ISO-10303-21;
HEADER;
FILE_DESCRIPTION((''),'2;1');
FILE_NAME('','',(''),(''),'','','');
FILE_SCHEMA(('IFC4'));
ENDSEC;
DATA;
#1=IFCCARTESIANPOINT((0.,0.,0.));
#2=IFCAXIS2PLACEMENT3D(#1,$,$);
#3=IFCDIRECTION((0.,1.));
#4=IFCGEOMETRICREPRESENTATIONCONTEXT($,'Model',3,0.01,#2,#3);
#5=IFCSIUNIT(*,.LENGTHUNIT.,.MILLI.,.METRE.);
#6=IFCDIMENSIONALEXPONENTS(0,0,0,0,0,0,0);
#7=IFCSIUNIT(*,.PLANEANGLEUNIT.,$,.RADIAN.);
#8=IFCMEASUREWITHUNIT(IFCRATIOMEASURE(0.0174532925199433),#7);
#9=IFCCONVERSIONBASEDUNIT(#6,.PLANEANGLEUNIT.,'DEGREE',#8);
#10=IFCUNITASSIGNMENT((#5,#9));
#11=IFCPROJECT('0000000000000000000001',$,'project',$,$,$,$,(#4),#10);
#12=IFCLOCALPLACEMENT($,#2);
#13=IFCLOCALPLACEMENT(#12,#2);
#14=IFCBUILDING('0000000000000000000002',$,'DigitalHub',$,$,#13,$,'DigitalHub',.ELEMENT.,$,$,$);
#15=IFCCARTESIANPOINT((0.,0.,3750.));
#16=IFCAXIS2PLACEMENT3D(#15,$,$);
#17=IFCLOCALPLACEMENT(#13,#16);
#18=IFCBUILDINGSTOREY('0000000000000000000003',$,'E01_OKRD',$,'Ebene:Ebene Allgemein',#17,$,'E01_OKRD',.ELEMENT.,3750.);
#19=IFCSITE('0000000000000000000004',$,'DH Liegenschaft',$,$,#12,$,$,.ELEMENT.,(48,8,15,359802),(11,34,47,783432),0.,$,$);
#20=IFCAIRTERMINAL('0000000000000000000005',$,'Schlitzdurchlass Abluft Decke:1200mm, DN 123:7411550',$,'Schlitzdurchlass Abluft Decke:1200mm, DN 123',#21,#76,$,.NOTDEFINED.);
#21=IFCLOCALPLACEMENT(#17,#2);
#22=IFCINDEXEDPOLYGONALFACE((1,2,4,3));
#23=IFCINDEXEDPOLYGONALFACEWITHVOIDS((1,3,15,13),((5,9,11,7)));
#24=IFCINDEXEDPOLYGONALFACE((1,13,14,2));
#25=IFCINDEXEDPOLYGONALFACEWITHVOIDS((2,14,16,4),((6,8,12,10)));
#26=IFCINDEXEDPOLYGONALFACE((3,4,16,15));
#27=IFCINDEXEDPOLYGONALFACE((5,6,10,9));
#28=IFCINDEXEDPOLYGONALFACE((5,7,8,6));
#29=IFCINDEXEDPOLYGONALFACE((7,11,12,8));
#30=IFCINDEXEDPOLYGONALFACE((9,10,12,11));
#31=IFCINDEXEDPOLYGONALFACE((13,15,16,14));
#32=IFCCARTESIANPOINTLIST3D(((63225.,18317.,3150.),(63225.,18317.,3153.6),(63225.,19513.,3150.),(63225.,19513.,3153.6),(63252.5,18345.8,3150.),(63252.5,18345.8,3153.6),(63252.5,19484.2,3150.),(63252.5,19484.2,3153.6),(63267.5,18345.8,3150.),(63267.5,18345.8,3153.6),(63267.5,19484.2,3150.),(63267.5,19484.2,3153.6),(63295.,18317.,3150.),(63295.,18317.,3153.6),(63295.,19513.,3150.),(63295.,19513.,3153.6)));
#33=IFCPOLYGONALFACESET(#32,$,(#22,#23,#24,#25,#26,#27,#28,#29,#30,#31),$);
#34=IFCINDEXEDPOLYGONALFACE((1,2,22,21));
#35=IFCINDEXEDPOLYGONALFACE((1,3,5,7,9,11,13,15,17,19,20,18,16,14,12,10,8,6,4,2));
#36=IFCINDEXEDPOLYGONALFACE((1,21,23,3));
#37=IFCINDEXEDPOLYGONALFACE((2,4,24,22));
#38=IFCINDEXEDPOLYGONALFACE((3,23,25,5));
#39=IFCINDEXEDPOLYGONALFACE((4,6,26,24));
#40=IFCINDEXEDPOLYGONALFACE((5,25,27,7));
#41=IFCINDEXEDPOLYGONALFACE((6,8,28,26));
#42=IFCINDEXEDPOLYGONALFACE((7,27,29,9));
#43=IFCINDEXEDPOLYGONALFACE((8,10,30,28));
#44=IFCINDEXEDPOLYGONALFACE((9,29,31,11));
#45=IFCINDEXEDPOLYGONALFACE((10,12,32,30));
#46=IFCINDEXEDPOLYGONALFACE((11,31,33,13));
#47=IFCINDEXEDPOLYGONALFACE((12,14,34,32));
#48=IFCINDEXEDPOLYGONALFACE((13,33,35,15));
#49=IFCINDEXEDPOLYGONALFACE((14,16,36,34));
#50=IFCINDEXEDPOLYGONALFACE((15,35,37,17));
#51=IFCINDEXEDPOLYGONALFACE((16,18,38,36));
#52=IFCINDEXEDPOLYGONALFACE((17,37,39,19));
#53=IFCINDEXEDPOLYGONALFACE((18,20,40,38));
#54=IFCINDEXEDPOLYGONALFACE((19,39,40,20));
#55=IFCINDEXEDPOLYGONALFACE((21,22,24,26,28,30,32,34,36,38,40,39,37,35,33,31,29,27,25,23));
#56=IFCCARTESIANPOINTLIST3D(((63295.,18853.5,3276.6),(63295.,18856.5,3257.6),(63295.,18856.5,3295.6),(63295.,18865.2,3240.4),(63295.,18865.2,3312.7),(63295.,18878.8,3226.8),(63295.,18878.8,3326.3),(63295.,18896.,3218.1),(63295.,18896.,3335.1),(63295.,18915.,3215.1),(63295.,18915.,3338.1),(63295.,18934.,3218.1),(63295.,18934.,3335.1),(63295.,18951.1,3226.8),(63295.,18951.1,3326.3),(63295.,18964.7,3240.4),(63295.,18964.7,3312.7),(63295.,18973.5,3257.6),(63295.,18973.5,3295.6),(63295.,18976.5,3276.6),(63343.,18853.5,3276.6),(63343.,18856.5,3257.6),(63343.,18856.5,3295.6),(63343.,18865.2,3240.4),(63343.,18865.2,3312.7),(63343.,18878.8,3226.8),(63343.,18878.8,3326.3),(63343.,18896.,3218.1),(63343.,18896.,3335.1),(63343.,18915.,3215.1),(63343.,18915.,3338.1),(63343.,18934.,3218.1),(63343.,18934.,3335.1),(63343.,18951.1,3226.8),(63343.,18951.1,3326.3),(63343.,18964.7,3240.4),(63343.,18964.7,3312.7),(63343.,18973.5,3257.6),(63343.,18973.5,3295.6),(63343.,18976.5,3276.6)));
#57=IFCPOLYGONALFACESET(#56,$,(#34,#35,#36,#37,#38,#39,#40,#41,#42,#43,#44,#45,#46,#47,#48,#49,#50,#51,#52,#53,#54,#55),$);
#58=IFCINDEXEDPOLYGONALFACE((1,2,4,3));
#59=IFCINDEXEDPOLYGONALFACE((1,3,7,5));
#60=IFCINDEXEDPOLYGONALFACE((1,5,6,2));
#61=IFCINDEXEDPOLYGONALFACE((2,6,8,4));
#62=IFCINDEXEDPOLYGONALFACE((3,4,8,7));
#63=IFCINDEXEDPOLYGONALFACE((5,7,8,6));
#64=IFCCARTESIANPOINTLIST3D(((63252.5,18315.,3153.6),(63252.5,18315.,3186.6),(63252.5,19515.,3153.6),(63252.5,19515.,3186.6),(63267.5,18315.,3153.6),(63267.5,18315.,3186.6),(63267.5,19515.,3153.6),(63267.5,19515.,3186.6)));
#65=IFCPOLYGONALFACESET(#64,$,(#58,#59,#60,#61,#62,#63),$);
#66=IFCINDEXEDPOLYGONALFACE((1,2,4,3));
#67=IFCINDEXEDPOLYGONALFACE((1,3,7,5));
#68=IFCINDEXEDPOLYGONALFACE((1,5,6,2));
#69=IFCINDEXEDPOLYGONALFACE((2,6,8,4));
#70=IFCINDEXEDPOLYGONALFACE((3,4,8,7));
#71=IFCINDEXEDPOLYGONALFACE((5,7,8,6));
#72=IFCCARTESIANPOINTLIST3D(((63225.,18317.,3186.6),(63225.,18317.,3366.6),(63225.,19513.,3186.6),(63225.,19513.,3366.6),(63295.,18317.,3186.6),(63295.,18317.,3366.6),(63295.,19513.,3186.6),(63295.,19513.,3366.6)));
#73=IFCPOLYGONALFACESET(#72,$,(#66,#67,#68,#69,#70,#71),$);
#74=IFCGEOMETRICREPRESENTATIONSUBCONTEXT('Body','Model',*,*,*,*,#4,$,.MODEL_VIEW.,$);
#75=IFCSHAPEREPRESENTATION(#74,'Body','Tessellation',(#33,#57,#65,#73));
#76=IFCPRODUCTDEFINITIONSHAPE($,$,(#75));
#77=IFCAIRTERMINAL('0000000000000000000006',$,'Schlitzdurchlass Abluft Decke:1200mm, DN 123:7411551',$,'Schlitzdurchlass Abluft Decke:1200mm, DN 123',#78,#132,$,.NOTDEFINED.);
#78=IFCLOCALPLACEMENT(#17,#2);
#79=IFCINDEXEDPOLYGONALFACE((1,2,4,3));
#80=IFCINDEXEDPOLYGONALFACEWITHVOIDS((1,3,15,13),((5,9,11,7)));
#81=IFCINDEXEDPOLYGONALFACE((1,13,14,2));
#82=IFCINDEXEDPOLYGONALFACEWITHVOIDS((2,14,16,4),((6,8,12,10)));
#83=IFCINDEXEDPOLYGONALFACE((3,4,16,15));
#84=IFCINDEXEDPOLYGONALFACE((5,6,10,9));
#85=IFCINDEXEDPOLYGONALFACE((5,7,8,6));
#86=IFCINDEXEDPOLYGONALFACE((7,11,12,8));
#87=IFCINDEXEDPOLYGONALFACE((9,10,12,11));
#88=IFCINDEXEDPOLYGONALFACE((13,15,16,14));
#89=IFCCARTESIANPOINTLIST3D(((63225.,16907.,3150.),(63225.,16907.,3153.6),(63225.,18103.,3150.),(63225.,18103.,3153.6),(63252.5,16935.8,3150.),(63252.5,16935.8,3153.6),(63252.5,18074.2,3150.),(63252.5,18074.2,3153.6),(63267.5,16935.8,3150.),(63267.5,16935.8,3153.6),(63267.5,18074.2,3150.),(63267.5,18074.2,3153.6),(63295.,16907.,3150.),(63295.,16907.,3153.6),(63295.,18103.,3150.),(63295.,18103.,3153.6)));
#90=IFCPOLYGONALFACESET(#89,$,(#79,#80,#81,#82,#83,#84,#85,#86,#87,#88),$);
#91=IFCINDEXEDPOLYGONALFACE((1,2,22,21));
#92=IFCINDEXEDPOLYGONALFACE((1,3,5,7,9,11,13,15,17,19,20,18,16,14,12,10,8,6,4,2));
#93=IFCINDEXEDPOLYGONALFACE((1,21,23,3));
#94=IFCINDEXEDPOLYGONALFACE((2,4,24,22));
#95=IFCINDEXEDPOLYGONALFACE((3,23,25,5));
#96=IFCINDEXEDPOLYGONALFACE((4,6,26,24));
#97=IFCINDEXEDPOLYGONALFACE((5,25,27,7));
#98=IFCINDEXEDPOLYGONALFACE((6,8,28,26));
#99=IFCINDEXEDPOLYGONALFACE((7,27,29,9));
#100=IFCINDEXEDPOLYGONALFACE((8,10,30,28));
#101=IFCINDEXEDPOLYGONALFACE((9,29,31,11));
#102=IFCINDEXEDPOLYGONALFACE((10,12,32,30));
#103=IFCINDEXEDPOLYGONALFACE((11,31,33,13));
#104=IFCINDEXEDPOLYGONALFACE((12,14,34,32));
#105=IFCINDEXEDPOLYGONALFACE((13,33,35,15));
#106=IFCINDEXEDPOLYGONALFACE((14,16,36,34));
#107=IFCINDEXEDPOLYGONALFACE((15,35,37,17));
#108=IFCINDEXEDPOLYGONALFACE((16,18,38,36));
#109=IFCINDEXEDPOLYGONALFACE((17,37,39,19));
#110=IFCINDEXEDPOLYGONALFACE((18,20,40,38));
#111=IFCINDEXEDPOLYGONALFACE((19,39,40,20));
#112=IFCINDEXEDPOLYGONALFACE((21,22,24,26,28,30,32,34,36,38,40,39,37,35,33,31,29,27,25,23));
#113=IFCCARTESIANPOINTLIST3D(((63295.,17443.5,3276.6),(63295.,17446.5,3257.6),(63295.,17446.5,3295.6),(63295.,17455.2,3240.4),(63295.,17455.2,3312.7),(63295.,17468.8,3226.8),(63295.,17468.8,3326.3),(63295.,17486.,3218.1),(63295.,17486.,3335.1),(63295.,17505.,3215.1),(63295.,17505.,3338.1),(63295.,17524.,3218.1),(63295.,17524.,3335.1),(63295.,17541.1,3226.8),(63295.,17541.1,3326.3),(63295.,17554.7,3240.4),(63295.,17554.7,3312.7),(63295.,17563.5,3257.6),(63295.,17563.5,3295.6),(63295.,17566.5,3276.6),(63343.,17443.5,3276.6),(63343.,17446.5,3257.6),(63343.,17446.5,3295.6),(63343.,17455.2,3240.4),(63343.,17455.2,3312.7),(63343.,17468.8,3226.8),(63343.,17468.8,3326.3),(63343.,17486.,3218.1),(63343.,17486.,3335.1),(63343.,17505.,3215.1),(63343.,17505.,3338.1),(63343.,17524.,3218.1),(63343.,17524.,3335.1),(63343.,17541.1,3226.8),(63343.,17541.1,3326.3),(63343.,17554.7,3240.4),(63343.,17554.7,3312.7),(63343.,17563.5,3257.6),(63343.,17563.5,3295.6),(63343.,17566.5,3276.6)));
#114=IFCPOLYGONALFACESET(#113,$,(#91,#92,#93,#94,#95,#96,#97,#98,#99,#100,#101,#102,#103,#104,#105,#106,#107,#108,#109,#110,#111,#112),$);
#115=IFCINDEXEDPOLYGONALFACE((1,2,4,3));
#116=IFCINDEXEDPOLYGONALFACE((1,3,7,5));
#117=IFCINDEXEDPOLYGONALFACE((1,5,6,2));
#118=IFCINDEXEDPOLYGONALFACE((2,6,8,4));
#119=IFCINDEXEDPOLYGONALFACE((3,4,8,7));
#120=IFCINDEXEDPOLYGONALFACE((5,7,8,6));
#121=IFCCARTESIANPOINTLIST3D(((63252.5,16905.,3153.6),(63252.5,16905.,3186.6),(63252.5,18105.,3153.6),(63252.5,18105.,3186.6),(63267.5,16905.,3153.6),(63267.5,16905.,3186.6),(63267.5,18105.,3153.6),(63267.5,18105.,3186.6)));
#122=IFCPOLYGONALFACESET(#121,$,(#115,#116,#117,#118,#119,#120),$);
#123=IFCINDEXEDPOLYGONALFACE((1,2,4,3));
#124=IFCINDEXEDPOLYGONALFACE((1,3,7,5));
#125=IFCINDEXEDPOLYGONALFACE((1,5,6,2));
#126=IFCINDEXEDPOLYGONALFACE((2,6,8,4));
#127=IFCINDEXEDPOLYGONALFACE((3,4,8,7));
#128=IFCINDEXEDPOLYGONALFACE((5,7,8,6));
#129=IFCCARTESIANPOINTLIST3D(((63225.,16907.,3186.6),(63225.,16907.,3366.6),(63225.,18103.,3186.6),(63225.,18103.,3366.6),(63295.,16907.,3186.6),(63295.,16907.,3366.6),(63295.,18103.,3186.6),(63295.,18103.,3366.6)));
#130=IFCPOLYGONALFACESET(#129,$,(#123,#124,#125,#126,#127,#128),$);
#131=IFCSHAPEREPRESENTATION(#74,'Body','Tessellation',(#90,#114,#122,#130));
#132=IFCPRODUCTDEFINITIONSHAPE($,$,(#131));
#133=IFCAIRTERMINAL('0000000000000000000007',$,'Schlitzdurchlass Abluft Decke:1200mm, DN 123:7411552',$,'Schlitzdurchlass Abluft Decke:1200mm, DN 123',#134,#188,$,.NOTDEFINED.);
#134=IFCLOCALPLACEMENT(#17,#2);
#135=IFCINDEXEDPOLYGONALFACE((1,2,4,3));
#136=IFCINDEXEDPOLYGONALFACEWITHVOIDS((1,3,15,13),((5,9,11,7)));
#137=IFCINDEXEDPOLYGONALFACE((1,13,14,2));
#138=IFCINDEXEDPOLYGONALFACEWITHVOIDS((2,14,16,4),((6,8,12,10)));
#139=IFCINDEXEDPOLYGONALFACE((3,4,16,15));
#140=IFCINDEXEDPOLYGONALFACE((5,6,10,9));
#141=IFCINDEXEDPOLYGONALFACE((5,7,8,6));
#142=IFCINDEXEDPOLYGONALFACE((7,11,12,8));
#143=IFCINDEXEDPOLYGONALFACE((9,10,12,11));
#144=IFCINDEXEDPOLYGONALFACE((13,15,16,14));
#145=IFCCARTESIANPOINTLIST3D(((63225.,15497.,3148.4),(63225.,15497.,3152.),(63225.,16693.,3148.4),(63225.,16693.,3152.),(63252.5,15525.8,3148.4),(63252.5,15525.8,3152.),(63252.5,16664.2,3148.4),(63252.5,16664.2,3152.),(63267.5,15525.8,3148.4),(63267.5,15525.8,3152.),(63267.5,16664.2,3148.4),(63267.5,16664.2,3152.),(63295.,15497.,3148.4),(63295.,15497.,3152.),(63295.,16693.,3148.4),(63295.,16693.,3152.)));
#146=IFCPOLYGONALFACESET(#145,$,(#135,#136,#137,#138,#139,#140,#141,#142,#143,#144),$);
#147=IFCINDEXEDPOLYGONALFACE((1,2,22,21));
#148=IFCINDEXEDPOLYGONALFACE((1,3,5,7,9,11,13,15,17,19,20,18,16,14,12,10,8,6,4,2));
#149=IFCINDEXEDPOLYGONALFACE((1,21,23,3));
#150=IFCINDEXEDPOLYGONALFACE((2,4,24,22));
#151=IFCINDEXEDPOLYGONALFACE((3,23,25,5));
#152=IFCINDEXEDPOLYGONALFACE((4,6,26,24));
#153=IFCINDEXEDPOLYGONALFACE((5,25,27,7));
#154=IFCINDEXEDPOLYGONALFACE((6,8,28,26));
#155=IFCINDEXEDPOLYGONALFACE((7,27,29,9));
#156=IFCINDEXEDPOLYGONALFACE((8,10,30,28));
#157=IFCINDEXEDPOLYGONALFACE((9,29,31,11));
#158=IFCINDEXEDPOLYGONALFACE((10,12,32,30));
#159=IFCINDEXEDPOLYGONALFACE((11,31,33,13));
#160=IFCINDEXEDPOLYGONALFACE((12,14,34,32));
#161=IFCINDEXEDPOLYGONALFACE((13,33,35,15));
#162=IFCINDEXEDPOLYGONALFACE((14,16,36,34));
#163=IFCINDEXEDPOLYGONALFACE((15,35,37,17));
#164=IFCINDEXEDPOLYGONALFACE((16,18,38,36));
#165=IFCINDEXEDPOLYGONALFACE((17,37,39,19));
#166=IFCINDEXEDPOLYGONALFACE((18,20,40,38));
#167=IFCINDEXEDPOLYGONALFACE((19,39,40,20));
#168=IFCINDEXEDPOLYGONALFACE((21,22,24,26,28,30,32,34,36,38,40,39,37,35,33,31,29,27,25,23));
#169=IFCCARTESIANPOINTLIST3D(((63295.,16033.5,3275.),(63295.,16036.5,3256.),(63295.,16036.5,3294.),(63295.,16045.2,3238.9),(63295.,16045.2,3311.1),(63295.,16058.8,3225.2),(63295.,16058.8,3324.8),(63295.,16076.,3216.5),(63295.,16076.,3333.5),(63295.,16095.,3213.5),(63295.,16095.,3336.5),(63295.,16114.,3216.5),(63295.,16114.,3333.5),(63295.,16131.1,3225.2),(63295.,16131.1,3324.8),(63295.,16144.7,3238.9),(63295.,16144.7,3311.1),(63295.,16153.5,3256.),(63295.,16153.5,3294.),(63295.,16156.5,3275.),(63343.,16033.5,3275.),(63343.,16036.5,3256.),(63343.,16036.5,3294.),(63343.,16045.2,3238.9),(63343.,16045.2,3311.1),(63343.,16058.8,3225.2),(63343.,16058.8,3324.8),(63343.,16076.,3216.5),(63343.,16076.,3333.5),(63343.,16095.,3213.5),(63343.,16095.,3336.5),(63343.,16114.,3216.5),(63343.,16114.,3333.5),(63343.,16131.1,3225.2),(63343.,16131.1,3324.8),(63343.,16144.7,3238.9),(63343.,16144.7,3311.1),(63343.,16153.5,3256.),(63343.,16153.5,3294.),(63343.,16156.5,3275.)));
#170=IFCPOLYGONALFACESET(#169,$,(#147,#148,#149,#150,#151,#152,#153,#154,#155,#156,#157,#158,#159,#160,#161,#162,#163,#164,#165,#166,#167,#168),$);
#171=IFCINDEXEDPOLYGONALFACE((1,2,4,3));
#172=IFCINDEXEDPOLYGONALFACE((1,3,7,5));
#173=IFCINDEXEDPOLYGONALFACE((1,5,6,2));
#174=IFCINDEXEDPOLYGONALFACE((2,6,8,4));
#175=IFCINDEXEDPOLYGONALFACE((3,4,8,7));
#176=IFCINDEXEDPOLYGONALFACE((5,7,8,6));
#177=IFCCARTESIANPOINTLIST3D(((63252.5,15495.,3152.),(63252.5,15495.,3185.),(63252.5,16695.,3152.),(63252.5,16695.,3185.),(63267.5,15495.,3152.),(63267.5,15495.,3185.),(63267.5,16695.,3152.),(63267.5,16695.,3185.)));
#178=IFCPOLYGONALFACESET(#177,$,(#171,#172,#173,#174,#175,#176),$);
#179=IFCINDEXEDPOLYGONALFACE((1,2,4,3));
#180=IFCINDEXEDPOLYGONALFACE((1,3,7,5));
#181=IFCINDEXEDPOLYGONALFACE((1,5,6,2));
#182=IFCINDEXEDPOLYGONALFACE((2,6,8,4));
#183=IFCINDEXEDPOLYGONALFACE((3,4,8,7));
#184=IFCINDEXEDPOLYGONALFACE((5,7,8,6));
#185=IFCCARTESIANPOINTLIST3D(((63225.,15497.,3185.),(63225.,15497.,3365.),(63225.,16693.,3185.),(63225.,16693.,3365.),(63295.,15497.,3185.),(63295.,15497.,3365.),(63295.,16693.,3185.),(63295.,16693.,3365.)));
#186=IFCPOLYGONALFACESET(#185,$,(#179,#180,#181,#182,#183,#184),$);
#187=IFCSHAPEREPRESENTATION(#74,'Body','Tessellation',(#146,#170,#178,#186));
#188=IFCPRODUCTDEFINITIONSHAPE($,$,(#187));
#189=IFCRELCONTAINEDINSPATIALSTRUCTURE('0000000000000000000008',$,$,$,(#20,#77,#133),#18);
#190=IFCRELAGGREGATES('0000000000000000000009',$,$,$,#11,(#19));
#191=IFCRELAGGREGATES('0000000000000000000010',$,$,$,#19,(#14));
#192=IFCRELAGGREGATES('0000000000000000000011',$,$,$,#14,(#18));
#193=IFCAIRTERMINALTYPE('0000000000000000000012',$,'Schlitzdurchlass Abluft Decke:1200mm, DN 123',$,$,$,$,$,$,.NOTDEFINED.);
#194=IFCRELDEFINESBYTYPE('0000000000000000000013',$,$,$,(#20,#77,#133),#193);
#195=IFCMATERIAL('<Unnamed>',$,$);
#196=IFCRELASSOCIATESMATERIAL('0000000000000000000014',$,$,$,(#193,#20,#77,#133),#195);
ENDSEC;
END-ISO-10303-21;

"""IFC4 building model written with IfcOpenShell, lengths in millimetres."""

from ifc_helpers import new_model, entity, si_unit, converted_unit, direction, frame, origin, place, context, subcontext, project, spatial, indexed_curve, outline, extrude, source, transform, mapped, material, type_object, type_shapes, element, save


model = new_model("IFC4")

# Units and contexts
model_context = context("Model", 3, precision=0.01, world=origin(), true_north=direction((0.0, 1.0)))
body_context = subcontext(model_context, "Body", "Model", "MODEL_VIEW")
ifc_project = project(units=[si_unit("LENGTHUNIT", "METRE", prefix="MILLI"), converted_unit("PLANEANGLEUNIT", "DEGREE", entity("IfcRatioMeasure", 0.0174532925199433), si_unit("PLANEANGLEUNIT", "RADIAN"), dimensions=[0, 0, 0, 0, 0, 0, 0])], contexts=[model_context])

# Site, building, storey
site_placement = place(None, origin())
site = spatial("IfcSite", under=ifc_project, at=site_placement, Name="DH Liegenschaft", CompositionType="ELEMENT", RefLatitude=(48, 8, 15, 359802), RefLongitude=(11, 34, 47, 783432), RefElevation=0.0)
building_placement = place(site_placement, origin())
building = spatial("IfcBuilding", under=site, at=building_placement, Name="DigitalHub", LongName="DigitalHub", CompositionType="ELEMENT")
storey_placement = place(building_placement, frame((0.0, 0.0, 3750.0)))
storey = spatial("IfcBuildingStorey", under=building, at=storey_placement, Name="E01_OKRD", ObjectType="Ebene:Ebene Allgemein", LongName="E01_OKRD", CompositionType="ELEMENT", Elevation=3750.0)

# Shared definitions
ifc_material_1 = material(Name="<Unnamed>")

# Air terminals
air_terminal_type_1 = type_object("IfcAirTerminalType", Name="Schlitzdurchlass Abluft Decke:1200mm, DN 123", PredefinedType="NOTDEFINED", material=ifc_material_1)
shared_shape_1 = source(origin(), body_context, "Body", "SweptSolid", [
    extrude(outline(indexed_curve([(-598.0, -35.0), (598.0, -35.0), (598.0, 35.0), (-598.0, 35.0), (-598.0, -35.0)], self_intersect=False), holes=[indexed_curve([(-569.2, -7.5), (-569.2, 7.5), (569.2, 7.5), (569.2, -7.5), (-569.2, -7.5)], self_intersect=False)]), frame((0.0, 0.0, 0.0), z_axis=(0.0, 0.0, 1.0), x_axis=(-1.0, 0.0, 0.0)), (0.0, 0.0, 1.0), 3.6),
    extrude(outline(indexed_curve([(61.5, 0.0), (58.5, 19.0), (49.8, 36.1), (36.1, 49.8), (19.0, 58.5), (0.0, 61.5), (-19.0, 58.5), (-36.1, 49.8), (-49.8, 36.1), (-58.5, 19.0), (-61.5, 0.0), (-58.5, -19.0), (-49.8, -36.1), (-36.1, -49.8), (-19.0, -58.5), (0.0, -61.5), (19.0, -58.5), (36.1, -49.8), (49.8, -36.1), (58.5, -19.0), (61.5, 0.0)], self_intersect=False)), frame((0.0, 35.0, 126.6), z_axis=(0.0, 1.0, 0.0), x_axis=(-1.0, 0.0, 0.0)), (0.0, 0.0, 1.0), 48.0),
    extrude(outline(indexed_curve([(-600.0, -7.5), (600.0, -7.5), (600.0, 7.5), (-600.0, 7.5), (-600.0, -7.5)], self_intersect=False)), frame((0.0, 0.0, 3.6), z_axis=(0.0, 0.0, 1.0), x_axis=(-1.0, 0.0, 0.0)), (0.0, 0.0, 1.0), 33.0),
    extrude(outline(indexed_curve([(-598.0, -35.0), (598.0, -35.0), (598.0, 35.0), (-598.0, 35.0), (-598.0, -35.0)], self_intersect=False)), frame((0.0, 0.0, 36.6), z_axis=(0.0, 0.0, 1.0), x_axis=(-1.0, 0.0, 0.0)), (0.0, 0.0, 1.0), 180.0),
])
type_shapes(air_terminal_type_1, [shared_shape_1])
for number, where, z_axis, x_axis, name in (
    (1, (63260.0, 18915.0, 3150.0), (0.0, 0.0, 1.0), (0.0, -1.0, 0.0), "Schlitzdurchlass Abluft Decke:1200mm, DN 123:7411550"),
    (2, (63260.0, 17505.0, 3150.0), (0.0, 0.0, 1.0), (0.0, -1.0, 0.0), "Schlitzdurchlass Abluft Decke:1200mm, DN 123:7411551"),
    (3, (63260.0, 16095.0, 3148.4), (0.0, 0.0, 1.0), (0.0, -1.0, 0.0), "Schlitzdurchlass Abluft Decke:1200mm, DN 123:7411552"),
):
    element("IfcAirTerminal", number, at=place(storey_placement, frame(where, z_axis=z_axis, x_axis=x_axis)), inside=storey, type_object=air_terminal_type_1, material=ifc_material_1, Name=name, ObjectType="Schlitzdurchlass Abluft Decke:1200mm, DN 123", PredefinedType="NOTDEFINED", context=body_context, shape_type="MappedRepresentation", body=[
        mapped(shared_shape_1, transform((0.0, 0.0, 0.0), scale=1.0)),
    ])

save(model, "model.ifc")
